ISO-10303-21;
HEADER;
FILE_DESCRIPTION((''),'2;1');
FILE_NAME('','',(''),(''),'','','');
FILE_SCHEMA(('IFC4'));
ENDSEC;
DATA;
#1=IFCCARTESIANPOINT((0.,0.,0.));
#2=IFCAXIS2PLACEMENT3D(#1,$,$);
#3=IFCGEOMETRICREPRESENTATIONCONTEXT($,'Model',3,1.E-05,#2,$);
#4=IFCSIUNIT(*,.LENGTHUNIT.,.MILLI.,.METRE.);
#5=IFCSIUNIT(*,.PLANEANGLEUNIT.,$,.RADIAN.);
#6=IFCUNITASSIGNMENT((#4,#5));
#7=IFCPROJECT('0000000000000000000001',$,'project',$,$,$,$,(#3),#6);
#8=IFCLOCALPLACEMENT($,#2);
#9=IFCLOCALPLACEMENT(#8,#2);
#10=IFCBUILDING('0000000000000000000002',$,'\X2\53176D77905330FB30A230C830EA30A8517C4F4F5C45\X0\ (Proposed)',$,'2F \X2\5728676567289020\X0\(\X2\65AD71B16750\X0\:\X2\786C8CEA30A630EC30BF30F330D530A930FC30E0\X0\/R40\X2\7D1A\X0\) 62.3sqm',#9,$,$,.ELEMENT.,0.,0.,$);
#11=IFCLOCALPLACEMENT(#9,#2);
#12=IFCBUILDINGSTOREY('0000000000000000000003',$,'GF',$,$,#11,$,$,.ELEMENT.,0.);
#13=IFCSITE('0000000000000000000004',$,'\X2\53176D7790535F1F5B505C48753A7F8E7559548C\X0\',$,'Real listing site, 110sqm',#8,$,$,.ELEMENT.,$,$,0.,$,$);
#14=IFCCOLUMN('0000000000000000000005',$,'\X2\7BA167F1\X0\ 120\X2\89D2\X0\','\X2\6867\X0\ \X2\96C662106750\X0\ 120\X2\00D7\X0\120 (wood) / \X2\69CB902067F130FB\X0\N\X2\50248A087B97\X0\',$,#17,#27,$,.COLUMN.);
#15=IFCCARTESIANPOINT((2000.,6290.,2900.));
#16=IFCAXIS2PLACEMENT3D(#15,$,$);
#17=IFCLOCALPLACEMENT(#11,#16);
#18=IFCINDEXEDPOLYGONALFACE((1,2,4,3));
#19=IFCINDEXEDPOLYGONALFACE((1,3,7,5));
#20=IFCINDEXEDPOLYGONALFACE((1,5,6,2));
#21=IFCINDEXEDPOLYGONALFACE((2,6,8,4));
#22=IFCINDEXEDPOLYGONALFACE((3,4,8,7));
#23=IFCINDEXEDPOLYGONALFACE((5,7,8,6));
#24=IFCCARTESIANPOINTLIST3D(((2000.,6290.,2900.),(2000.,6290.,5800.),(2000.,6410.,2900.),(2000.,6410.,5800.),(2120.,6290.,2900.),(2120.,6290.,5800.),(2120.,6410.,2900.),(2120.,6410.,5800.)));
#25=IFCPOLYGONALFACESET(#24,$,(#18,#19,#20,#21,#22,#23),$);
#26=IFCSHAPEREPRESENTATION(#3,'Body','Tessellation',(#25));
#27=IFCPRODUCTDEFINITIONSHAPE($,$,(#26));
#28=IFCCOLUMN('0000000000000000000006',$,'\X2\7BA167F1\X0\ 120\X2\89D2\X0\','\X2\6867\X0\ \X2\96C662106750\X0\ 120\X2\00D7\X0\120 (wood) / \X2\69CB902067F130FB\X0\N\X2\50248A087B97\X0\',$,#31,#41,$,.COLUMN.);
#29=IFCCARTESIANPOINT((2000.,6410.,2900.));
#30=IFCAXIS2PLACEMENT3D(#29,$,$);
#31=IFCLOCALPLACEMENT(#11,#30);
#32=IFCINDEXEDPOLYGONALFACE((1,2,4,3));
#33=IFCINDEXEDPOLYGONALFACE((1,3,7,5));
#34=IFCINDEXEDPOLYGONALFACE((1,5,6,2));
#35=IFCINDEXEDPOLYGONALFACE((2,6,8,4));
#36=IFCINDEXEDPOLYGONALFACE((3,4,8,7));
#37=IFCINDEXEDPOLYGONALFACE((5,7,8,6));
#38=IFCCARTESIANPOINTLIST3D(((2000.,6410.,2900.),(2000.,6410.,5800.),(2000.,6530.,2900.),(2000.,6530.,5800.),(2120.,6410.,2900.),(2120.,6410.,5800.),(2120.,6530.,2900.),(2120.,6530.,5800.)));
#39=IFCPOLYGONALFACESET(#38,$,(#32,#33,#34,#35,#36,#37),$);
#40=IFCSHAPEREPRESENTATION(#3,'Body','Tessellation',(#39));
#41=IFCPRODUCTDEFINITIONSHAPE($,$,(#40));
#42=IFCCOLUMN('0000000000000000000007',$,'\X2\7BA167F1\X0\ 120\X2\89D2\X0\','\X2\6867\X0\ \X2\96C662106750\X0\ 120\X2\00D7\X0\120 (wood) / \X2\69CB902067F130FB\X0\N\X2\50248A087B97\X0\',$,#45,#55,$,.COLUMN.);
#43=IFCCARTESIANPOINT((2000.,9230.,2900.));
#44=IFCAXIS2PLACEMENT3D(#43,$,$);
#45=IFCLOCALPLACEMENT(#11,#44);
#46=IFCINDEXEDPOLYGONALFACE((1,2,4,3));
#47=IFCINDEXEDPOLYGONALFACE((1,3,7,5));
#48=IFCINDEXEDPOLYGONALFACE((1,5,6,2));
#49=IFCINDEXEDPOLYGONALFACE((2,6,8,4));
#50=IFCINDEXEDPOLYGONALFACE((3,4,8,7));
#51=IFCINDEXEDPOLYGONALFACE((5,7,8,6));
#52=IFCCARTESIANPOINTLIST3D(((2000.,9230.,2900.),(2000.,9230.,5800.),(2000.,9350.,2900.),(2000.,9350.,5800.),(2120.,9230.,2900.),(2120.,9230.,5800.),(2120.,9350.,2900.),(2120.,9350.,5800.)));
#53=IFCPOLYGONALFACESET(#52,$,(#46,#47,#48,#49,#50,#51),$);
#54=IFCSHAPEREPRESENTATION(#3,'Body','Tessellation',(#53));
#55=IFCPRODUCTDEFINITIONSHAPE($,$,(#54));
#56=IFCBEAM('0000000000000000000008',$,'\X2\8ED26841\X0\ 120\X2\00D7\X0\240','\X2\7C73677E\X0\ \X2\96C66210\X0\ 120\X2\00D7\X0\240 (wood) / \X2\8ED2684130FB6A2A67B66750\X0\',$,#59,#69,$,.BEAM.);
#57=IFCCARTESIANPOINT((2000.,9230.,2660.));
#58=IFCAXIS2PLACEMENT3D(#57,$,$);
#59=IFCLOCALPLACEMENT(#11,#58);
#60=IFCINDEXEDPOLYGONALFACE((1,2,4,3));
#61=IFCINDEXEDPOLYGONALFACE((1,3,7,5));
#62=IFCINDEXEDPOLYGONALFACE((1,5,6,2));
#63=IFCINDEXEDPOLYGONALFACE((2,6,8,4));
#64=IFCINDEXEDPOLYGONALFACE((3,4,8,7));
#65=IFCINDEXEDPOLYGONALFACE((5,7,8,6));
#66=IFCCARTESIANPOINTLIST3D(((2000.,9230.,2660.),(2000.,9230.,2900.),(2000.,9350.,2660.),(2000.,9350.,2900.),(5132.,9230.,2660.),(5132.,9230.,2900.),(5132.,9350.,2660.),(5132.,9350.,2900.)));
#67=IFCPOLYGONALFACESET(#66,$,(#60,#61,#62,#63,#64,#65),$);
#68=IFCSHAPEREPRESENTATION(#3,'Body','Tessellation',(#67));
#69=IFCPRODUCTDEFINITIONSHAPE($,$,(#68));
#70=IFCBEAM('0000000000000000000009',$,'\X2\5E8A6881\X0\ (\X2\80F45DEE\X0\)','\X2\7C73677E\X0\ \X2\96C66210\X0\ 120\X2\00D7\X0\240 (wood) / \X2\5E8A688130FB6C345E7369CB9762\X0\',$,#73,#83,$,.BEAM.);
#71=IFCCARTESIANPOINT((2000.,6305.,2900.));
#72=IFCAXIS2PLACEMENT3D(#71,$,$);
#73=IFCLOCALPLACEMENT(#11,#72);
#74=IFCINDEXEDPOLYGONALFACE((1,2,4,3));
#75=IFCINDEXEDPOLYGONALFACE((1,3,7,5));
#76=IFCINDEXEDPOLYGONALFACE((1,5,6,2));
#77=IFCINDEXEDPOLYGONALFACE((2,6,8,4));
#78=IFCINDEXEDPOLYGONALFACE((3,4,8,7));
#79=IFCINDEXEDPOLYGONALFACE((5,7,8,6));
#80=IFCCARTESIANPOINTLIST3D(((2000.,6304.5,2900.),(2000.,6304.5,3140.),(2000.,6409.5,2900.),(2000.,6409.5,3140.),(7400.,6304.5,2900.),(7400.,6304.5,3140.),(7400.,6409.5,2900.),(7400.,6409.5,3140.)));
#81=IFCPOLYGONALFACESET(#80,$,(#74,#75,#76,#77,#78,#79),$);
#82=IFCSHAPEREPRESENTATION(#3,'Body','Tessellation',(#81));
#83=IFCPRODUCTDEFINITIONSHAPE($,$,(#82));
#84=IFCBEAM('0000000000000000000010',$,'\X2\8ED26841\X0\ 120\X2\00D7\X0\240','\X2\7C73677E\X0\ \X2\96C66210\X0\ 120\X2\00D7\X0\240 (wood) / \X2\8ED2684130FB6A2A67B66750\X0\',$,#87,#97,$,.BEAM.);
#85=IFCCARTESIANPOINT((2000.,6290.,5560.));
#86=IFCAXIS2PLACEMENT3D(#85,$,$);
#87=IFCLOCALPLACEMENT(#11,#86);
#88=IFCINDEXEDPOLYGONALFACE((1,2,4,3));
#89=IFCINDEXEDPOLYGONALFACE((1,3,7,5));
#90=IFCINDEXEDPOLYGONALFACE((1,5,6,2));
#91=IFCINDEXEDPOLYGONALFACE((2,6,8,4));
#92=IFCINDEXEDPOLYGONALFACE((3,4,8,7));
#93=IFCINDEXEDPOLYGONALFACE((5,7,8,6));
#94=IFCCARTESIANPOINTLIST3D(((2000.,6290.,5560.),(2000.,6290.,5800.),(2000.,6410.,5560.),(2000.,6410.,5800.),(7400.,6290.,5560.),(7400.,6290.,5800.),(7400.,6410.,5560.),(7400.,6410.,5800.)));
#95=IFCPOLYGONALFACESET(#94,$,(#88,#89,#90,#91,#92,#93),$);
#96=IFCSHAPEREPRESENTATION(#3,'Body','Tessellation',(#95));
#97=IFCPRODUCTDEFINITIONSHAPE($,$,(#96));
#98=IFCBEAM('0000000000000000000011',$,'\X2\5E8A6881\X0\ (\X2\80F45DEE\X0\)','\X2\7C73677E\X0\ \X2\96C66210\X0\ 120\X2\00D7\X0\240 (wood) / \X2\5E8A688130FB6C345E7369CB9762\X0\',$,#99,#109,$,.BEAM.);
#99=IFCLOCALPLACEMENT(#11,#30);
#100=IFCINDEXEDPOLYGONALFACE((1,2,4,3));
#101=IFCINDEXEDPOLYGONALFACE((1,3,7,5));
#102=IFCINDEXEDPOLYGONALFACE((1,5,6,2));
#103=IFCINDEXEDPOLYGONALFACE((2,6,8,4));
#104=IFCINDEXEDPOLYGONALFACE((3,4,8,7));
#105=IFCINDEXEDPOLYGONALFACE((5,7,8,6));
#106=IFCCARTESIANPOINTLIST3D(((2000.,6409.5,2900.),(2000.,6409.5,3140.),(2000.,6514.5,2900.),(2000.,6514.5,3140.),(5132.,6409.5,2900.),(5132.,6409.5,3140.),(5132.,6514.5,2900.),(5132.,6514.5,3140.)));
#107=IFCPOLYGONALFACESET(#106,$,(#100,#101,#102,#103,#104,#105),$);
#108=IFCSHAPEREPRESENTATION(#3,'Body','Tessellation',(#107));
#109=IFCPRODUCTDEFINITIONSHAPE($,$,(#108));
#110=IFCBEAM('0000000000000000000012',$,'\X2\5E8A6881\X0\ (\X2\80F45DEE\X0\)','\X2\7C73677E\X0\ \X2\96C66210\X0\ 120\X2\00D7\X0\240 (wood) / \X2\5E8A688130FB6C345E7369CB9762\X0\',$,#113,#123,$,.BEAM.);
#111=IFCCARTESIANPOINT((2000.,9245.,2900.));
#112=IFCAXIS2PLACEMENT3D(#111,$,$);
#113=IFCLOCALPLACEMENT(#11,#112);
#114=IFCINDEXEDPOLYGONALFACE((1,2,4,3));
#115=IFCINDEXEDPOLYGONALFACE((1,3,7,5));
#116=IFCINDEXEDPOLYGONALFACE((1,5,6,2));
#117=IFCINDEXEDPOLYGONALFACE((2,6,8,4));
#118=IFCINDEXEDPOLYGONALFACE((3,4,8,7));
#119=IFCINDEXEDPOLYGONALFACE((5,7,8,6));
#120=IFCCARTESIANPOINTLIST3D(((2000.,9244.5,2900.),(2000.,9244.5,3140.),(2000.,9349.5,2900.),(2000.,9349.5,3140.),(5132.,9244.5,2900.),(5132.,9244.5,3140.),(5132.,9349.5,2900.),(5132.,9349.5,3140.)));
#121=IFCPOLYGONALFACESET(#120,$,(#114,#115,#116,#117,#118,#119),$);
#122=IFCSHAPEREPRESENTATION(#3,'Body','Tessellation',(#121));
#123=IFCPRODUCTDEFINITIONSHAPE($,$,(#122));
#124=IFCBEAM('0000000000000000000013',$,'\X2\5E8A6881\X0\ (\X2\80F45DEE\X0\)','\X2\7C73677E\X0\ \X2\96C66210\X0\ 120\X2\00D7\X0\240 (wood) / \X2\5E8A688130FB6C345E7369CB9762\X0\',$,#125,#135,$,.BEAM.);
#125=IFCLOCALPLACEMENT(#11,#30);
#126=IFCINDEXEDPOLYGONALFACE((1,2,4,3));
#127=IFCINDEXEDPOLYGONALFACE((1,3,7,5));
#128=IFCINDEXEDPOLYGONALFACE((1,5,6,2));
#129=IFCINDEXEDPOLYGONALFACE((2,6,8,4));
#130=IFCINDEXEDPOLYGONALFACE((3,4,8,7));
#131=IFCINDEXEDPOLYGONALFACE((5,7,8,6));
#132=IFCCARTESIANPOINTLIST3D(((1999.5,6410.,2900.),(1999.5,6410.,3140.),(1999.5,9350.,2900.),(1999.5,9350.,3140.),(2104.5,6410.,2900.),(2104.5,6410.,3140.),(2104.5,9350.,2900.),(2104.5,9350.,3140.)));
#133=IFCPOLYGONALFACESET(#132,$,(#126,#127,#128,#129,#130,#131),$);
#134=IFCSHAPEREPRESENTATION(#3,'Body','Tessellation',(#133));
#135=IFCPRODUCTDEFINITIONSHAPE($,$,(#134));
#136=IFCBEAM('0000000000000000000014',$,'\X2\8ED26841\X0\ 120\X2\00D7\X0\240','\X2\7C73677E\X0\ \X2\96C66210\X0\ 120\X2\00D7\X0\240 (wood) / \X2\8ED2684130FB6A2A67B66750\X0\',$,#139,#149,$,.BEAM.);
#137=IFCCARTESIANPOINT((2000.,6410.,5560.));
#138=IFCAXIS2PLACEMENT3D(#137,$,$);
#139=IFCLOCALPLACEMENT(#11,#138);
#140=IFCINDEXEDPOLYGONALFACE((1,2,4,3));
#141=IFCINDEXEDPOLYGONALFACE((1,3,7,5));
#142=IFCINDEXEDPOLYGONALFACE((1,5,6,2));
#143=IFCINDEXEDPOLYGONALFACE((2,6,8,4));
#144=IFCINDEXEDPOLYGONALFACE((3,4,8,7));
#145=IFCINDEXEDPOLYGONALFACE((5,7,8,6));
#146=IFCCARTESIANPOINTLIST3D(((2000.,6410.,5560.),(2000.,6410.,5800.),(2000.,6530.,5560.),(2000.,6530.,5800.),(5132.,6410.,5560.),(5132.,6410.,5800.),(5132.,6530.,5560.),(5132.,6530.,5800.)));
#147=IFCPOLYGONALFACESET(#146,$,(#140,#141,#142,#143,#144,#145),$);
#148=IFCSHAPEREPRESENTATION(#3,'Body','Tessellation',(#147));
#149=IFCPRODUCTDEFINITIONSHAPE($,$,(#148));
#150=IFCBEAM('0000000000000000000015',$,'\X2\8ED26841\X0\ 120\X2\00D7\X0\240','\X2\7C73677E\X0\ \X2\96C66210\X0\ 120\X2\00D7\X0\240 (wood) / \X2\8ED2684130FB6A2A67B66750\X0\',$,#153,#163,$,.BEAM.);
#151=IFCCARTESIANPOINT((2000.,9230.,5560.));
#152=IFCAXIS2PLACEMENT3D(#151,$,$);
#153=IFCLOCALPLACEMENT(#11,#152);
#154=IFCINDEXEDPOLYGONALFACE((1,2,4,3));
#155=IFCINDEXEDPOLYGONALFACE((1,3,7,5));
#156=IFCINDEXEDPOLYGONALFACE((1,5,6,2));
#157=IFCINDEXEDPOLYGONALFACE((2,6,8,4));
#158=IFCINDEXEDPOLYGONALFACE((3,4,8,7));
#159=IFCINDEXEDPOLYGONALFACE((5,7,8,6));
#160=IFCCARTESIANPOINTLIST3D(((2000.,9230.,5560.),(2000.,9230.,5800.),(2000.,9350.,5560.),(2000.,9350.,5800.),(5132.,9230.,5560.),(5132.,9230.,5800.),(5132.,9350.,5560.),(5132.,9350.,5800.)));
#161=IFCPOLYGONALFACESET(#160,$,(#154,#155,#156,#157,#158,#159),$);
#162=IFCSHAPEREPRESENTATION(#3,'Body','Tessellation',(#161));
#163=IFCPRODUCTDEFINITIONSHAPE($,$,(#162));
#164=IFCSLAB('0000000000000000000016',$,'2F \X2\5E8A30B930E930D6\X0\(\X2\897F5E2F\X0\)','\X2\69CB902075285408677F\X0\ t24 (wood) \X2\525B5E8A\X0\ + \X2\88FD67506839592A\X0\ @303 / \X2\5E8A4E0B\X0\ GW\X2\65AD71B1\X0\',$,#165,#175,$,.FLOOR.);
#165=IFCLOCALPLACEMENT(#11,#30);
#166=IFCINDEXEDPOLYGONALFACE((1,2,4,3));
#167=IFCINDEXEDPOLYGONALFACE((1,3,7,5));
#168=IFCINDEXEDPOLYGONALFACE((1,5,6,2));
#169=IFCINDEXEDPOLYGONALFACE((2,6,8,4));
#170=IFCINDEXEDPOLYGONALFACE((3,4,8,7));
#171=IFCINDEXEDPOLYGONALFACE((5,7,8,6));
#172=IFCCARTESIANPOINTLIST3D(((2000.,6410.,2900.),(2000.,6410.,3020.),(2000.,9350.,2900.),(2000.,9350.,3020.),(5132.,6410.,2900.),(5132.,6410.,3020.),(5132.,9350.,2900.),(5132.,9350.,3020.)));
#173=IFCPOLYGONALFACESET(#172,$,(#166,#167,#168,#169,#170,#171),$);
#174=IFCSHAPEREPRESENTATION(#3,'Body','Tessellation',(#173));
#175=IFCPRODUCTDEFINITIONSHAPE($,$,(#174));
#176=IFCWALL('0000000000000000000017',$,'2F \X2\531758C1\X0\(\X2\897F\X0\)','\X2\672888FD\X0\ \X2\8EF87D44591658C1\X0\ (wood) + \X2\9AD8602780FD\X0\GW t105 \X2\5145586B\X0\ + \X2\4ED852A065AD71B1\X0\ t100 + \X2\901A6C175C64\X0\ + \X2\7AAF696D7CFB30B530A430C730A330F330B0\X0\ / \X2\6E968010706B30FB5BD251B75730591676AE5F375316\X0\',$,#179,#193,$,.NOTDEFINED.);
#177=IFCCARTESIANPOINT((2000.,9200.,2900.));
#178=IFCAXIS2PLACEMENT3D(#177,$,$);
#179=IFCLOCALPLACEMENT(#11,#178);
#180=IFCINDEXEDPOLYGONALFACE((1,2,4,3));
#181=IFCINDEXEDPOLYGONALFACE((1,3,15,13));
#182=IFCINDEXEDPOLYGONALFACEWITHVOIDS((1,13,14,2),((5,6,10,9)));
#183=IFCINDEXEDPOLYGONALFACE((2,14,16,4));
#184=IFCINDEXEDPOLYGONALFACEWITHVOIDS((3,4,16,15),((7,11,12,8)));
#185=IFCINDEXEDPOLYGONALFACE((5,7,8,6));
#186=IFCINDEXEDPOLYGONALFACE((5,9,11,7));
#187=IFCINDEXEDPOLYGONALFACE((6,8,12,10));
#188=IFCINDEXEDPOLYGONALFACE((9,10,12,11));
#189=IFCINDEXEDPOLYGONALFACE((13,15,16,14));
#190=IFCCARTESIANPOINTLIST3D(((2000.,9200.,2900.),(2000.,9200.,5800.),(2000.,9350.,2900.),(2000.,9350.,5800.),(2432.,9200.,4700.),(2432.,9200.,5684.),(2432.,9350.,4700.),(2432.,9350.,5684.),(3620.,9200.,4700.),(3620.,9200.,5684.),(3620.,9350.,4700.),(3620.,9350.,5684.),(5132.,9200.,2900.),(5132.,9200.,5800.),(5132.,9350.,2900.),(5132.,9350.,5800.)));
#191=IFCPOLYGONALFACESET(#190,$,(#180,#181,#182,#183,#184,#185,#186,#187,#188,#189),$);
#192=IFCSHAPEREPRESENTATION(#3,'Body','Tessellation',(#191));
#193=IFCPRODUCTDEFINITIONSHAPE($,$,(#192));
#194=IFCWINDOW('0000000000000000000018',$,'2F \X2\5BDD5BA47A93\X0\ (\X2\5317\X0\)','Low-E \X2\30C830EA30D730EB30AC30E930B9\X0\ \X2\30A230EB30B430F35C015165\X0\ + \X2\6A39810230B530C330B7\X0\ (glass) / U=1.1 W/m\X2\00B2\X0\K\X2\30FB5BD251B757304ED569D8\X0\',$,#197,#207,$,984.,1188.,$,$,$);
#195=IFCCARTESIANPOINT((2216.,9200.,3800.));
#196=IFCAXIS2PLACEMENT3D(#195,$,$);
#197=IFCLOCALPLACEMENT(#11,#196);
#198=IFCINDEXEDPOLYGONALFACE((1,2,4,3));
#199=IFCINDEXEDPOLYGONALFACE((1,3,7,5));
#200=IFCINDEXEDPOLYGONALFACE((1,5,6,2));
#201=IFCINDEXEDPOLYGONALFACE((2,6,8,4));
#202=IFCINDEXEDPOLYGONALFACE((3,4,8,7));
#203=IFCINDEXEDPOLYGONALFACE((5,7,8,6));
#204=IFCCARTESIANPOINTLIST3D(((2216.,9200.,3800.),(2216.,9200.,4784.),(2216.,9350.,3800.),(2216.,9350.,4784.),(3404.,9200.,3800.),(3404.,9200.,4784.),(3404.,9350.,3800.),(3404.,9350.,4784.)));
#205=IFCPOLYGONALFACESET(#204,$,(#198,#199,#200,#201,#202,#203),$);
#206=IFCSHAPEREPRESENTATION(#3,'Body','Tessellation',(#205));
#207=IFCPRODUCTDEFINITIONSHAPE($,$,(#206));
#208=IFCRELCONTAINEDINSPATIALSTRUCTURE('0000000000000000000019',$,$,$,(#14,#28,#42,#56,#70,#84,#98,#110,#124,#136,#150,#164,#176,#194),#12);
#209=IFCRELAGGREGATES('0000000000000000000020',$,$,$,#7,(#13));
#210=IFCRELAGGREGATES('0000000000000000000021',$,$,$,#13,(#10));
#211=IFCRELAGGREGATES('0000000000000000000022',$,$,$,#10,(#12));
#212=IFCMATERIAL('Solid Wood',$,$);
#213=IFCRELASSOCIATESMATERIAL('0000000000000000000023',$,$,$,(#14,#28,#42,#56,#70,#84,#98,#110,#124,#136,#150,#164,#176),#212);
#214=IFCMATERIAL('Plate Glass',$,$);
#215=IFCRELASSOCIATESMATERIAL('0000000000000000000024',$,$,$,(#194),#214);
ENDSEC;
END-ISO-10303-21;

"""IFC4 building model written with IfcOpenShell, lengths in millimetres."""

from ifc_helpers import new_model, si_unit, frame, frame_2d, origin, place, context, project, spatial, rectangle, extrude, material, element, fill, save


model = new_model("IFC4")

# Units and contexts
model_context = context("Model", 3, precision=1e-05, world=origin())
ifc_project = project(units=[si_unit("LENGTHUNIT", "METRE", prefix="MILLI"), si_unit("PLANEANGLEUNIT", "RADIAN")], contexts=[model_context])

# Site, building, storey
site_placement = place(None, origin())
site = spatial("IfcSite", under=ifc_project, at=site_placement, Name="北海道弟子屈町美留和", ObjectType="Real listing site, 110sqm", CompositionType="ELEMENT", RefElevation=0.0)
building_placement = place(site_placement, origin())
building = spatial("IfcBuilding", under=site, at=building_placement, Name="北海道・アトリエ兼住居 (Proposed)", ObjectType="2F 在来木造(断熱材:硬質ウレタンフォーム/R40級) 62.3sqm", CompositionType="ELEMENT", ElevationOfRefHeight=0.0, ElevationOfTerrain=0.0)
storey_placement = place(building_placement, origin())
storey = spatial("IfcBuildingStorey", under=building, at=storey_placement, Name="GF", CompositionType="ELEMENT", Elevation=0.0)

# Columns
ifc_material_1 = material(Name="Solid Wood")
column_1_placement = place(storey_placement, frame((2000.0, 6290.0, 2900.0)))
element("IfcColumn", 1, at=column_1_placement, inside=storey, material=ifc_material_1, Name="管柱 120角", Description="桧 集成材 120×120 (wood) / 構造柱・N値計算", PredefinedType="COLUMN", context=model_context, shape_type="SweptSolid", body=[
    extrude(rectangle(XDim=120.0, YDim=120.0, at=frame_2d((60.0, 60.0))), frame((2000.0, 6290.0, 2900.0)), (0.0, 0.0, 1.0), 2900.0),
])
column_2_placement = place(storey_placement, frame((2000.0, 6410.0, 2900.0)))
element("IfcColumn", 2, at=column_2_placement, inside=storey, material=ifc_material_1, Name="管柱 120角", Description="桧 集成材 120×120 (wood) / 構造柱・N値計算", PredefinedType="COLUMN", context=model_context, shape_type="SweptSolid", body=[
    extrude(rectangle(XDim=120.0, YDim=120.0, at=frame_2d((60.0, 60.0))), frame((2000.0, 6410.0, 2900.0)), (0.0, 0.0, 1.0), 2900.0),
])
column_3_placement = place(storey_placement, frame((2000.0, 9230.0, 2900.0)))
element("IfcColumn", 3, at=column_3_placement, inside=storey, material=ifc_material_1, Name="管柱 120角", Description="桧 集成材 120×120 (wood) / 構造柱・N値計算", PredefinedType="COLUMN", context=model_context, shape_type="SweptSolid", body=[
    extrude(rectangle(XDim=120.0, YDim=120.0, at=frame_2d((60.0, 60.0))), frame((2000.0, 9230.0, 2900.0)), (0.0, 0.0, 1.0), 2900.0),
])

# Beams
beam_1_placement = place(storey_placement, frame((2000.0, 9230.0, 2660.0)))
element("IfcBeam", 4, at=beam_1_placement, inside=storey, material=ifc_material_1, Name="軒桁 120×240", Description="米松 集成 120×240 (wood) / 軒桁・横架材", PredefinedType="BEAM", context=model_context, shape_type="SweptSolid", body=[
    extrude(rectangle(XDim=3132.0, YDim=120.0, at=frame_2d((1566.0, 60.0))), frame((2000.0, 9230.0, 2660.0)), (0.0, 0.0, 1.0), 240.0),
])
beam_2_placement = place(storey_placement, frame((2000.0, 6305.0, 2900.0)))
element("IfcBeam", 5, at=beam_2_placement, inside=storey, material=ifc_material_1, Name="床梁 (胴差)", Description="米松 集成 120×240 (wood) / 床梁・水平構面", PredefinedType="BEAM", context=model_context, shape_type="SweptSolid", body=[
    extrude(rectangle(XDim=5400.0, YDim=105.0, at=frame_2d((2700.0, 52.0))), frame((2000.0, 6305.0, 2900.0)), (0.0, 0.0, 1.0), 240.0),
])
beam_3_placement = place(storey_placement, frame((2000.0, 6290.0, 5560.0)))
element("IfcBeam", 6, at=beam_3_placement, inside=storey, material=ifc_material_1, Name="軒桁 120×240", Description="米松 集成 120×240 (wood) / 軒桁・横架材", PredefinedType="BEAM", context=model_context, shape_type="SweptSolid", body=[
    extrude(rectangle(XDim=5400.0, YDim=120.0, at=frame_2d((2700.0, 60.0))), frame((2000.0, 6290.0, 5560.0)), (0.0, 0.0, 1.0), 240.0),
])
beam_4_placement = place(storey_placement, frame((2000.0, 6410.0, 2900.0)))
element("IfcBeam", 7, at=beam_4_placement, inside=storey, material=ifc_material_1, Name="床梁 (胴差)", Description="米松 集成 120×240 (wood) / 床梁・水平構面", PredefinedType="BEAM", context=model_context, shape_type="SweptSolid", body=[
    extrude(rectangle(XDim=3132.0, YDim=105.0, at=frame_2d((1566.0, 52.0))), frame((2000.0, 6410.0, 2900.0)), (0.0, 0.0, 1.0), 240.0),
])
beam_5_placement = place(storey_placement, frame((2000.0, 9245.0, 2900.0)))
element("IfcBeam", 8, at=beam_5_placement, inside=storey, material=ifc_material_1, Name="床梁 (胴差)", Description="米松 集成 120×240 (wood) / 床梁・水平構面", PredefinedType="BEAM", context=model_context, shape_type="SweptSolid", body=[
    extrude(rectangle(XDim=3132.0, YDim=105.0, at=frame_2d((1566.0, 52.0))), frame((2000.0, 9245.0, 2900.0)), (0.0, 0.0, 1.0), 240.0),
])
beam_6_placement = place(storey_placement, frame((2000.0, 6410.0, 2900.0)))
element("IfcBeam", 9, at=beam_6_placement, inside=storey, material=ifc_material_1, Name="床梁 (胴差)", Description="米松 集成 120×240 (wood) / 床梁・水平構面", PredefinedType="BEAM", context=model_context, shape_type="SweptSolid", body=[
    extrude(rectangle(XDim=105.0, YDim=2940.0, at=frame_2d((52.0, 1470.0))), frame((2000.0, 6410.0, 2900.0)), (0.0, 0.0, 1.0), 240.0),
])
beam_7_placement = place(storey_placement, frame((2000.0, 6410.0, 5560.0)))
element("IfcBeam", 10, at=beam_7_placement, inside=storey, material=ifc_material_1, Name="軒桁 120×240", Description="米松 集成 120×240 (wood) / 軒桁・横架材", PredefinedType="BEAM", context=model_context, shape_type="SweptSolid", body=[
    extrude(rectangle(XDim=3132.0, YDim=120.0, at=frame_2d((1566.0, 60.0))), frame((2000.0, 6410.0, 5560.0)), (0.0, 0.0, 1.0), 240.0),
])
beam_8_placement = place(storey_placement, frame((2000.0, 9230.0, 5560.0)))
element("IfcBeam", 11, at=beam_8_placement, inside=storey, material=ifc_material_1, Name="軒桁 120×240", Description="米松 集成 120×240 (wood) / 軒桁・横架材", PredefinedType="BEAM", context=model_context, shape_type="SweptSolid", body=[
    extrude(rectangle(XDim=3132.0, YDim=120.0, at=frame_2d((1566.0, 60.0))), frame((2000.0, 9230.0, 5560.0)), (0.0, 0.0, 1.0), 240.0),
])

# Slab
slab_placement = place(storey_placement, frame((2000.0, 6410.0, 2900.0)))
element("IfcSlab", 12, at=slab_placement, inside=storey, material=ifc_material_1, Name="2F 床スラブ(西帯)", Description="構造用合板 t24 (wood) 剛床 + 製材根太 @303 / 床下 GW断熱", PredefinedType="FLOOR", context=model_context, shape_type="SweptSolid", body=[
    extrude(rectangle(XDim=3132.0, YDim=2940.0, at=frame_2d((1566.0, 1470.0))), frame((2000.0, 6410.0, 2900.0)), (0.0, 0.0, 1.0), 120.0),
])

# Wall, opening, window
wall_1_placement = place(storey_placement, frame((2000.0, 9200.0, 2900.0)))
wall_1 = element("IfcWall", 13, at=wall_1_placement, inside=storey, material=ifc_material_1, Name="2F 北壁(西)", Description="木製 軸組外壁 (wood) + 高性能GW t105 充填 + 付加断熱 t100 + 通気層 + 窯業系サイディング / 準耐火・寒冷地外皮強化", PredefinedType="NOTDEFINED", context=model_context, shape_type="SweptSolid", body=[
    extrude(rectangle(XDim=3132.0, YDim=150.0, at=frame_2d((1566.0, 75.0))), frame((2000.0, 9200.0, 2900.0)), (0.0, 0.0, 1.0), 2900.0),
])
opening_placement = place(storey_placement, frame((2216.0, 9200.0, 3800.0)))
opening = element("IfcOpeningElement", 14, at=opening_placement, cuts=wall_1, PredefinedType="NOTDEFINED", context=model_context, shape_type="SweptSolid", body=[
    extrude(rectangle(XDim=1188.0, YDim=150.0, at=frame_2d((594.0, 75.0))), frame((2216.0, 9200.0, 3800.0)), (0.0, 0.0, 1.0), 984.0),
])
ifc_material_2 = material(Name="Plate Glass")
window_placement = place(storey_placement, frame((2216.0, 9200.0, 3800.0)))
window = element("IfcWindow", 15, at=window_placement, inside=storey, material=ifc_material_2, Name="2F 寝室窓 (北)", Description="Low-E トリプルガラス アルゴン封入 + 樹脂サッシ (glass) / U=1.1 W/m²K・寒冷地仕様", OverallHeight=984.0, OverallWidth=1188.0, context=model_context, shape_type="SweptSolid", body=[
    extrude(rectangle(XDim=1188.0, YDim=150.0, at=frame_2d((594.0, 75.0))), frame((2216.0, 9200.0, 3800.0)), (0.0, 0.0, 1.0), 984.0),
])
fill(opening, window)

save(model, "model.ifc")
